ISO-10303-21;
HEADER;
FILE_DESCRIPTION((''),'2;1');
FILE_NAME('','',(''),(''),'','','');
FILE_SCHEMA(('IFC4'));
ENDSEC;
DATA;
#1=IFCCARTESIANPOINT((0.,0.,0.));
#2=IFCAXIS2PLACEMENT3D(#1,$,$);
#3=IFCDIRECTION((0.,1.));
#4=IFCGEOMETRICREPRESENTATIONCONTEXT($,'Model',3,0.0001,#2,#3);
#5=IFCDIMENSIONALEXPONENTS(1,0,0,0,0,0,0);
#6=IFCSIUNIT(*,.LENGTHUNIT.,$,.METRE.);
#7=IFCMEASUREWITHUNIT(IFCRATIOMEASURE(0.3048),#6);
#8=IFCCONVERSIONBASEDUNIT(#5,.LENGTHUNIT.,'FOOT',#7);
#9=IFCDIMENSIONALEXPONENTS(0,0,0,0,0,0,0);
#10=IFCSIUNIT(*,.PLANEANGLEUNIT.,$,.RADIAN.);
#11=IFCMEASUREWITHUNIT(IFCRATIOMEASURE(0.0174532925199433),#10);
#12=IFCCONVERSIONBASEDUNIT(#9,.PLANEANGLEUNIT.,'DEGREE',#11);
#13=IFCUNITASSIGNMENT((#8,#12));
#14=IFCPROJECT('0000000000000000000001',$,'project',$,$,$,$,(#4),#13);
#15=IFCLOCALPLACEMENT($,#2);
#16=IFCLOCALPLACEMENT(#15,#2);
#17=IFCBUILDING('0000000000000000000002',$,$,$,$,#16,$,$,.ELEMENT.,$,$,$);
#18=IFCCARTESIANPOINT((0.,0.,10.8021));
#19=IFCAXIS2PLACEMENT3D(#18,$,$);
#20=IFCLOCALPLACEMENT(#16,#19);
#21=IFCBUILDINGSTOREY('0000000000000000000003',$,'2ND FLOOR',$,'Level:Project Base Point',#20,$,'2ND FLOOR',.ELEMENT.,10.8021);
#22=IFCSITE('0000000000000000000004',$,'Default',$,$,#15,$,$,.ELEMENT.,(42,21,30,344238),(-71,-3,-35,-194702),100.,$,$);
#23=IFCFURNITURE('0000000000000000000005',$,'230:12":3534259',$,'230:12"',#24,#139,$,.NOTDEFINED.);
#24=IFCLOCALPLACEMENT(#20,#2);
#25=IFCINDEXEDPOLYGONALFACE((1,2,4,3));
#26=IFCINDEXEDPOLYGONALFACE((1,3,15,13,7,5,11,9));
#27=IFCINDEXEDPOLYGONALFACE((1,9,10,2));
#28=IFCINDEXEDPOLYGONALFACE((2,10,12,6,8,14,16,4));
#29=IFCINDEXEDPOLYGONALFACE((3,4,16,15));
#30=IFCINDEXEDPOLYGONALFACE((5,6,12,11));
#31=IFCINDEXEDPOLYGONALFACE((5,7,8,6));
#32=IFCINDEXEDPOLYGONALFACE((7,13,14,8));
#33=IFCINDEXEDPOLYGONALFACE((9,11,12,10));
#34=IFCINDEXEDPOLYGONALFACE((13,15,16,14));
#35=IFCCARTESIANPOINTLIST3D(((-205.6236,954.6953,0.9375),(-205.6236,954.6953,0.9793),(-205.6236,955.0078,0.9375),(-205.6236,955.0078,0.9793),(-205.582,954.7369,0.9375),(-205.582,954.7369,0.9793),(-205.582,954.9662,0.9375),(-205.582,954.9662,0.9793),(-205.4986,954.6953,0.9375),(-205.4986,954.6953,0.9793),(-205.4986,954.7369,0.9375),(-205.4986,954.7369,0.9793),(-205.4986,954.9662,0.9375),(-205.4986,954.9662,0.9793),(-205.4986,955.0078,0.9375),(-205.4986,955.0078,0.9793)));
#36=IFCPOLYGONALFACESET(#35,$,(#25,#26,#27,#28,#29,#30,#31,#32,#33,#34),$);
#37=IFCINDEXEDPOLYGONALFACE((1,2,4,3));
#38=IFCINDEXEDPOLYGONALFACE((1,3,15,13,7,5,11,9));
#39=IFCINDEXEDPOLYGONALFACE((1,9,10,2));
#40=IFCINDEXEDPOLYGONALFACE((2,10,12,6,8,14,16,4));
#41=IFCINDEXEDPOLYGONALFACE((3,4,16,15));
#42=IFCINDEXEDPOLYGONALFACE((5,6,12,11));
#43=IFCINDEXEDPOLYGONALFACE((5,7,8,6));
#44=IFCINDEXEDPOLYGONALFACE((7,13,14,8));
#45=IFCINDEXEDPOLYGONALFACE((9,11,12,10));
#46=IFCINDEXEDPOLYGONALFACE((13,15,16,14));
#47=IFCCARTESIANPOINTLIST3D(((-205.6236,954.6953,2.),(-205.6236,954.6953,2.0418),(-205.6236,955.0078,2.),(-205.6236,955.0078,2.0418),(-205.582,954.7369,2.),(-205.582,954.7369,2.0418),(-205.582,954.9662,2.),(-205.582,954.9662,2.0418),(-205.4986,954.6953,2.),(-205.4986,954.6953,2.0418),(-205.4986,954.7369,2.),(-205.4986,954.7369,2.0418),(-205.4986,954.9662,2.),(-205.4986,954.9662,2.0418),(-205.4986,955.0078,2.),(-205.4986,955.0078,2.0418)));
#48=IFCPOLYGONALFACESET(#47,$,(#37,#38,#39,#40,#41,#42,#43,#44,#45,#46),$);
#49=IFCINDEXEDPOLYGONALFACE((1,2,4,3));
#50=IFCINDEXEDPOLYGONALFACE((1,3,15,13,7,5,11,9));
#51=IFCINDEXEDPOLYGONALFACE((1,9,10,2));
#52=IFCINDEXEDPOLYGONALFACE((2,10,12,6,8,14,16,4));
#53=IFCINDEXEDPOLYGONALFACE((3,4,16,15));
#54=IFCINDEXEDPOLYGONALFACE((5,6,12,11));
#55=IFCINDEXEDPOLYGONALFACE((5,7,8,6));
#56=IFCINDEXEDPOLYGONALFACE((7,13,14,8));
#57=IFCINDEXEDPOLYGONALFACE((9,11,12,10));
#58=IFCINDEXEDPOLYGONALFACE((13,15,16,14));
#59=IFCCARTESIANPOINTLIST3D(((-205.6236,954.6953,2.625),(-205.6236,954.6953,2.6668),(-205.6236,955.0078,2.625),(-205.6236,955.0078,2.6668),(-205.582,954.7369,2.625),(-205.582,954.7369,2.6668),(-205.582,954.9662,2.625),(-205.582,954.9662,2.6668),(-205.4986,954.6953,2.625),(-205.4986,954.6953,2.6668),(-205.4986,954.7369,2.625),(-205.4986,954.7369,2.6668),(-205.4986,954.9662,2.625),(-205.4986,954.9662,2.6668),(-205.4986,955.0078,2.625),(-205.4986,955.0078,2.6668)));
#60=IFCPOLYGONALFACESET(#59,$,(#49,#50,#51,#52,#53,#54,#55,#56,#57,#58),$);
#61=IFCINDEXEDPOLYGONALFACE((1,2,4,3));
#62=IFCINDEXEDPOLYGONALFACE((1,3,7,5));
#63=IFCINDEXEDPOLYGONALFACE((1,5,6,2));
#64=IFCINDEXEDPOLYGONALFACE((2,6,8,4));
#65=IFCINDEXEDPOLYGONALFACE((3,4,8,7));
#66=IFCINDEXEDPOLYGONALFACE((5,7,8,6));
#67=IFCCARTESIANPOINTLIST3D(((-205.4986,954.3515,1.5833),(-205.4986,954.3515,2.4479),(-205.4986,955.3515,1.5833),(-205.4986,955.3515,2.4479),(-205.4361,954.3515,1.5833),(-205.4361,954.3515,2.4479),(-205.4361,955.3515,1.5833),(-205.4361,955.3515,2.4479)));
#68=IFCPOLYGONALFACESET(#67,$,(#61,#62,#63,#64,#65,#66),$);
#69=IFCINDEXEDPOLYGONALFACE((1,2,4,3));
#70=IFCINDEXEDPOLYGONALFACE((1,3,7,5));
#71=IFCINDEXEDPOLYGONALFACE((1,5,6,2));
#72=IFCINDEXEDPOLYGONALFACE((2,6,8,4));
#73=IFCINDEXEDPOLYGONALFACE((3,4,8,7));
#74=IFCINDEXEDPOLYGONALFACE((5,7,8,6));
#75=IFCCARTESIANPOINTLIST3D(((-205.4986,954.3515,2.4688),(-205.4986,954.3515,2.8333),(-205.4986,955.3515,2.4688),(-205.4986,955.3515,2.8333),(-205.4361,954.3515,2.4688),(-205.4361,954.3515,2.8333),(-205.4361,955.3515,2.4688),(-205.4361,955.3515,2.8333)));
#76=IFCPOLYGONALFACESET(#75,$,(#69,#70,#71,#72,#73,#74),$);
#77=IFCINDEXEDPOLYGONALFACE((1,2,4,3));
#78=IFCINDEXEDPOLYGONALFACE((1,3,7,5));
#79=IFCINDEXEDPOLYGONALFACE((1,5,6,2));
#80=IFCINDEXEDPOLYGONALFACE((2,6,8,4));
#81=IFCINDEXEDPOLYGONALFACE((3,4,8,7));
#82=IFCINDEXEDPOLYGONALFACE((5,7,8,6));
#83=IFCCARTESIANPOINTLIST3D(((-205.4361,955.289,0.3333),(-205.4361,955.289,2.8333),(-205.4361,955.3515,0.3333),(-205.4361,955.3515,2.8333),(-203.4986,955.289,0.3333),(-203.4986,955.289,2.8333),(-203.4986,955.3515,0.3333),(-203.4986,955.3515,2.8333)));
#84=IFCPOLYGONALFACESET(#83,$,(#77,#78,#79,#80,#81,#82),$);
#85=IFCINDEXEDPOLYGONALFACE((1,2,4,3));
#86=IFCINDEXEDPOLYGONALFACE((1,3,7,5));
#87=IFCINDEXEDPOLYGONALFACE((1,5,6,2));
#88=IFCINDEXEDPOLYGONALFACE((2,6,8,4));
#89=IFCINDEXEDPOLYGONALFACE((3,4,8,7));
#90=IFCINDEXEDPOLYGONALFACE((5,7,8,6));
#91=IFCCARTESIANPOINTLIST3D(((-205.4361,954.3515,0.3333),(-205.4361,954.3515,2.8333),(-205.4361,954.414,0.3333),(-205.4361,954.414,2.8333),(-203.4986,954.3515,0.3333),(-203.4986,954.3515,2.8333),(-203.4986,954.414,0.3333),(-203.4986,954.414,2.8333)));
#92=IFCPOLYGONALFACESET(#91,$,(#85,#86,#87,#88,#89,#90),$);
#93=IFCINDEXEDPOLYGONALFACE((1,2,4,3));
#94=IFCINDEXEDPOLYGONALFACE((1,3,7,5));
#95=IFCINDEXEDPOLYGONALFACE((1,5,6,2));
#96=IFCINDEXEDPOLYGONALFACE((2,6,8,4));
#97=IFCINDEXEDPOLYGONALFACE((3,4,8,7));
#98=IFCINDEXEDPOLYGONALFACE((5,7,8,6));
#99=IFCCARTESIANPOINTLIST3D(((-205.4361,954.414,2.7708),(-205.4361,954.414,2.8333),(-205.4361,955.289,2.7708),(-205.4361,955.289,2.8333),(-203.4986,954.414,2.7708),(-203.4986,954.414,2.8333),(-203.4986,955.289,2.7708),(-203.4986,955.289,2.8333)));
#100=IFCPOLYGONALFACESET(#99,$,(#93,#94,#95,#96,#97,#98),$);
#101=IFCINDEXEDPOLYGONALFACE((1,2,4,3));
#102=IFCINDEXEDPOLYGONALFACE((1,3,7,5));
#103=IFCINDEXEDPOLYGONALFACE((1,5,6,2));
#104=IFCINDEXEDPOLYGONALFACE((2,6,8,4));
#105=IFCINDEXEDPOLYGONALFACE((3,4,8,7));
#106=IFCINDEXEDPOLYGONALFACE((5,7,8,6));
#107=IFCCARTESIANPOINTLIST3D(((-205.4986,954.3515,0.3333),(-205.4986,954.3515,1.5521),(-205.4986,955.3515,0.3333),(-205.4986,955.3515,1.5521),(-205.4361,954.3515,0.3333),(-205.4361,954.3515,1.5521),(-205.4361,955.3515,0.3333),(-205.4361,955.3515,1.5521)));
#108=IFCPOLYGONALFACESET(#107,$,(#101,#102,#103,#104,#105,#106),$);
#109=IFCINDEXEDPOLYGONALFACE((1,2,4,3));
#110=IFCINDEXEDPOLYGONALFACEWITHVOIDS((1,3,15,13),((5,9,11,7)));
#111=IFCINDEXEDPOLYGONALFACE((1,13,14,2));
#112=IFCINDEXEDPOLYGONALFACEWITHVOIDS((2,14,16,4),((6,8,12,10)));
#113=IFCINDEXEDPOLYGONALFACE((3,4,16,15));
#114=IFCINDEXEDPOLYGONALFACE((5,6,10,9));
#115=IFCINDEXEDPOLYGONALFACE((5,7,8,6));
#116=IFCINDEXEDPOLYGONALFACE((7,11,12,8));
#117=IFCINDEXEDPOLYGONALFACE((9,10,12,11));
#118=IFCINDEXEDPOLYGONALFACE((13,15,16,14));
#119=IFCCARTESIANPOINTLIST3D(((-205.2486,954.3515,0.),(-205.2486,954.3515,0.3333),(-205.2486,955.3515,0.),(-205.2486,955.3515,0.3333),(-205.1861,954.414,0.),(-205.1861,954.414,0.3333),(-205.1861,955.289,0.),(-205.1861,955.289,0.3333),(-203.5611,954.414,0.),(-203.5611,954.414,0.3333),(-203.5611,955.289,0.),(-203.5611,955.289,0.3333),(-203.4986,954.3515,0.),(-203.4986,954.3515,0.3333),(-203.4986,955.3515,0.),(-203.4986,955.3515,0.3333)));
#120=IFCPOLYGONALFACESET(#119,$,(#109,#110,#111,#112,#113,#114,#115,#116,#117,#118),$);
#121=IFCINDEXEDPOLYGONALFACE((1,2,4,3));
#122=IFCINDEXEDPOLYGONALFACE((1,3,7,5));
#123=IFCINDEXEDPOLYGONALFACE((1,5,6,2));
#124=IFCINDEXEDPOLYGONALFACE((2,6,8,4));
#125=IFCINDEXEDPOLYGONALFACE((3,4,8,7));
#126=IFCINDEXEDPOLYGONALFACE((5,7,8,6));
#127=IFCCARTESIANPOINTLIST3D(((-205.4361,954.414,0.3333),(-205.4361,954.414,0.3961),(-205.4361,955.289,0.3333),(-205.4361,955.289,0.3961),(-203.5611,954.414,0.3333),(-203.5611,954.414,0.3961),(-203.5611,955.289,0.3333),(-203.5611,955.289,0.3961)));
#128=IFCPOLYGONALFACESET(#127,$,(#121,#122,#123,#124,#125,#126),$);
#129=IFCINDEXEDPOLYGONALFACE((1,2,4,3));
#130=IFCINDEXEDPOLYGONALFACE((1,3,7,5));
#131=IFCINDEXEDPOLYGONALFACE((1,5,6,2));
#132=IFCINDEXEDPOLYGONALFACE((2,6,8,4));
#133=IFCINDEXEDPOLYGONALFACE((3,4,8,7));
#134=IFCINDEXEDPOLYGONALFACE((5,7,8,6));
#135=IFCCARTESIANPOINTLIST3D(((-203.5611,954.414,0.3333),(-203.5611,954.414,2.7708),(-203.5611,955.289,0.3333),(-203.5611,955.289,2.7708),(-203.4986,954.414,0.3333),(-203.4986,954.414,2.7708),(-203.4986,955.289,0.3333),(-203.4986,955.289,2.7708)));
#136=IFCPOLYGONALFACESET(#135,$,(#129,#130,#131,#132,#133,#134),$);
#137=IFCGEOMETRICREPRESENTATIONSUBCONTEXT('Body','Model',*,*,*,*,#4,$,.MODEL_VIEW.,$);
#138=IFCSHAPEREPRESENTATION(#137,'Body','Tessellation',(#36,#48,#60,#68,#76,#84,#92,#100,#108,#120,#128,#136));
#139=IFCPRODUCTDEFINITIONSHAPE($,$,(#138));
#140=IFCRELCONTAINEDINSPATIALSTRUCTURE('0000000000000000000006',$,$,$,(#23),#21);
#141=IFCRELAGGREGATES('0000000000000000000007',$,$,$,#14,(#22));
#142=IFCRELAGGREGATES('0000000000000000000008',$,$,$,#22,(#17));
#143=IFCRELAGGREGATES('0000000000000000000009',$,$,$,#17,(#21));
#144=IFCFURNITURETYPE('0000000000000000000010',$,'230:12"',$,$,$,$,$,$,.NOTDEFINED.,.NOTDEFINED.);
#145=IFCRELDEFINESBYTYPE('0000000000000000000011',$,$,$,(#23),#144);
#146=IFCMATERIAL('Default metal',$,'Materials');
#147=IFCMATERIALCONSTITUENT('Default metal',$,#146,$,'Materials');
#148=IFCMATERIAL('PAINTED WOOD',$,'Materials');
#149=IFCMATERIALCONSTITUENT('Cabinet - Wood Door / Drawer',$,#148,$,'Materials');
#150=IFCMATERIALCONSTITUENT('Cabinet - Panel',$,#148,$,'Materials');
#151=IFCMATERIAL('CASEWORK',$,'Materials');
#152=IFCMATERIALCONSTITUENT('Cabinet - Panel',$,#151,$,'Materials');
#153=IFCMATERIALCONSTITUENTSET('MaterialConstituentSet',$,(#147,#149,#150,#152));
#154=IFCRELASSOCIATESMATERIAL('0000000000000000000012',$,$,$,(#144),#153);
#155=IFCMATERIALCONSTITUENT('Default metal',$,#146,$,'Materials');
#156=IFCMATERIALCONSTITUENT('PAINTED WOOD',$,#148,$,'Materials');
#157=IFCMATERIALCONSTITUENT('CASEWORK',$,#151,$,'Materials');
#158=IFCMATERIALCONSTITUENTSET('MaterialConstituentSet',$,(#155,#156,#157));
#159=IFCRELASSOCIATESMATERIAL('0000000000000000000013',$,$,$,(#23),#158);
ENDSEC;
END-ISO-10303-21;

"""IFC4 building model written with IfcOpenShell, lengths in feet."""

from ifc_helpers import new_model, entity, si_unit, converted_unit, direction, frame, frame_2d, origin, origin_2d_with_axis, place, context, subcontext, project, spatial, polyline, rectangle, outline, extrude, source, transform, mapped, material, constituent, constituent_set, type_object, type_shapes, element, save


model = new_model("IFC4")

# Units and contexts
model_context = context("Model", 3, precision=0.0001, world=origin(), true_north=direction((0.0, 1.0)))
body_context = subcontext(model_context, "Body", "Model", "MODEL_VIEW")
ifc_project = project(units=[converted_unit("LENGTHUNIT", "FOOT", entity("IfcRatioMeasure", 0.3048), si_unit("LENGTHUNIT", "METRE"), dimensions=[1, 0, 0, 0, 0, 0, 0]), converted_unit("PLANEANGLEUNIT", "DEGREE", entity("IfcRatioMeasure", 0.0174532925199433), si_unit("PLANEANGLEUNIT", "RADIAN"), dimensions=[0, 0, 0, 0, 0, 0, 0])], contexts=[model_context])

# Site, building, storey
site_placement = place(None, origin())
site = spatial("IfcSite", under=ifc_project, at=site_placement, Name="Default", CompositionType="ELEMENT", RefLatitude=(42, 21, 30, 344238), RefLongitude=(-71, -3, -35, -194702), RefElevation=100.0)
building_placement = place(site_placement, origin())
building = spatial("IfcBuilding", under=site, at=building_placement, CompositionType="ELEMENT")
storey_placement = place(building_placement, frame((0.0, 0.0, 10.8021)))
storey = spatial("IfcBuildingStorey", under=building, at=storey_placement, Name="2ND FLOOR", ObjectType="Level:Project Base Point", LongName="2ND FLOOR", CompositionType="ELEMENT", Elevation=10.8021)

# Furniture
ifc_material_1 = material(Name="CASEWORK", Category="Materials")
ifc_material_2 = material(Name="PAINTED WOOD", Category="Materials")
ifc_material_3 = material(Name="Default metal", Category="Materials")
ifc_constituent_1 = constituent(ifc_material_3, Name="Default metal", Category="Materials")
ifc_constituent_2 = constituent(ifc_material_2, Name="PAINTED WOOD", Category="Materials")
ifc_constituent_3 = constituent(ifc_material_1, Name="CASEWORK", Category="Materials")
ifc_constituent_set_1 = constituent_set(constituents=[ifc_constituent_1, ifc_constituent_2, ifc_constituent_3], Name="MaterialConstituentSet")
ifc_constituent_4 = constituent(ifc_material_3, Name="Default metal", Category="Materials")
ifc_constituent_5 = constituent(ifc_material_2, Name="Cabinet - Wood Door / Drawer", Category="Materials")
ifc_constituent_6 = constituent(ifc_material_2, Name="Cabinet - Panel", Category="Materials")
ifc_constituent_7 = constituent(ifc_material_1, Name="Cabinet - Panel", Category="Materials")
ifc_constituent_set_2 = constituent_set(constituents=[ifc_constituent_4, ifc_constituent_5, ifc_constituent_6, ifc_constituent_7], Name="MaterialConstituentSet")
furniture_type_1 = type_object("IfcFurnitureType", Name="230:12\"", AssemblyPlace="NOTDEFINED", PredefinedType="NOTDEFINED", material=ifc_constituent_set_2)
shared_shape_1 = source(origin(), body_context, "Body", "SweptSolid", [
    extrude(outline(polyline([(-0.0521, -0.1562), (0.0729, -0.1562), (0.0729, 0.1562), (-0.0521, 0.1562), (-0.0521, 0.1146), (0.0313, 0.1146), (0.0313, -0.1146), (-0.0521, -0.1146), (-0.0521, -0.1562)])), frame((0.0615, -2.0521, 0.9375), z_axis=(0.0, 0.0, 1.0), x_axis=(0.0, -1.0, 0.0)), (0.0, 0.0, 1.0), 0.0418),
    extrude(outline(polyline([(-0.0521, -0.1562), (0.0729, -0.1562), (0.0729, 0.1562), (-0.0521, 0.1562), (-0.0521, 0.1146), (0.0313, 0.1146), (0.0313, -0.1146), (-0.0521, -0.1146), (-0.0521, -0.1562)])), frame((0.0615, -2.0521, 2.0), z_axis=(0.0, 0.0, 1.0), x_axis=(0.0, -1.0, 0.0)), (0.0, 0.0, 1.0), 0.0418),
    extrude(outline(polyline([(-0.0521, -0.1562), (0.0729, -0.1562), (0.0729, 0.1562), (-0.0521, 0.1562), (-0.0521, 0.1146), (0.0313, 0.1146), (0.0313, -0.1146), (-0.0521, -0.1146), (-0.0521, -0.1562)])), frame((0.0615, -2.0521, 2.625), z_axis=(0.0, 0.0, 1.0), x_axis=(0.0, -1.0, 0.0)), (0.0, 0.0, 1.0), 0.0418),
    extrude(rectangle(XDim=0.0625, YDim=1.0, at=origin_2d_with_axis()), frame((0.0615, -1.9688, 1.5833), z_axis=(0.0, 0.0, 1.0), x_axis=(0.0, 1.0, 0.0)), (0.0, 0.0, 1.0), 0.8646),
    extrude(rectangle(XDim=0.0625, YDim=1.0, at=origin_2d_with_axis()), frame((0.0615, -1.9688, 2.4688), z_axis=(0.0, 0.0, 1.0), x_axis=(0.0, 1.0, 0.0)), (0.0, 0.0, 1.0), 0.3646),
    extrude(rectangle(XDim=0.0625, YDim=1.9375, at=frame_2d((0.0, 0.0), x_axis=(1.0, 0.0))), frame((-0.4073, -0.9687, 0.3333)), (0.0, 0.0, 1.0), 2.5),
    extrude(rectangle(XDim=0.0625, YDim=1.9375, at=frame_2d((0.0, 0.0), x_axis=(1.0, 0.0))), frame((0.5302, -0.9687, 0.3333)), (0.0, 0.0, 1.0), 2.5),
    extrude(rectangle(XDim=0.875, YDim=1.9375, at=origin_2d_with_axis()), frame((0.0615, -0.9687, 2.7708), z_axis=(0.0, 0.0, 1.0), x_axis=(-1.0, 0.0, 0.0)), (0.0, 0.0, 1.0), 0.0625),
    extrude(rectangle(XDim=0.0625, YDim=1.0, at=origin_2d_with_axis()), frame((0.0615, -1.9688, 0.3333), z_axis=(0.0, 0.0, 1.0), x_axis=(0.0, 1.0, 0.0)), (0.0, 0.0, 1.0), 1.2187),
    extrude(outline(polyline([(-0.5, -0.875), (0.5, -0.875), (0.5, 0.875), (-0.5, 0.875), (-0.5, -0.875)]), holes=[polyline([(-0.4375, -0.8125), (-0.4375, 0.8125), (0.4375, 0.8125), (0.4375, -0.8125), (-0.4375, -0.8125)])]), frame((0.0615, -0.875, 0.0)), (0.0, 0.0, 1.0), 0.3333),
    extrude(rectangle(XDim=0.875, YDim=1.875, at=frame_2d((0.0, 0.0), x_axis=(1.0, 0.0))), frame((0.0615, -1.0, 0.3333), z_axis=(0.0, 0.0, 1.0), x_axis=(-1.0, 0.0, 0.0)), (0.0, 0.0, 1.0), 0.0627),
    extrude(rectangle(XDim=0.0625, YDim=0.875, at=origin_2d_with_axis()), frame((0.0615, -0.0312, 0.3333), z_axis=(0.0, 0.0, 1.0), x_axis=(0.0, 1.0, 0.0)), (0.0, 0.0, 1.0), 2.4375),
])
type_shapes(furniture_type_1, [shared_shape_1])
furniture_1_placement = place(storey_placement, frame((-203.4986, 954.913, 0.0), z_axis=(0.0, 0.0, 1.0), x_axis=(0.0, -1.0, 0.0)))
element("IfcFurniture", 1, at=furniture_1_placement, inside=storey, type_object=furniture_type_1, material=ifc_constituent_set_1, Name="230:12\":3534259", ObjectType="230:12\"", PredefinedType="NOTDEFINED", context=body_context, shape_type="MappedRepresentation", body=[
    mapped(shared_shape_1, transform((0.0, 0.0, 0.0), scale=1.0)),
])

save(model, "model.ifc")
